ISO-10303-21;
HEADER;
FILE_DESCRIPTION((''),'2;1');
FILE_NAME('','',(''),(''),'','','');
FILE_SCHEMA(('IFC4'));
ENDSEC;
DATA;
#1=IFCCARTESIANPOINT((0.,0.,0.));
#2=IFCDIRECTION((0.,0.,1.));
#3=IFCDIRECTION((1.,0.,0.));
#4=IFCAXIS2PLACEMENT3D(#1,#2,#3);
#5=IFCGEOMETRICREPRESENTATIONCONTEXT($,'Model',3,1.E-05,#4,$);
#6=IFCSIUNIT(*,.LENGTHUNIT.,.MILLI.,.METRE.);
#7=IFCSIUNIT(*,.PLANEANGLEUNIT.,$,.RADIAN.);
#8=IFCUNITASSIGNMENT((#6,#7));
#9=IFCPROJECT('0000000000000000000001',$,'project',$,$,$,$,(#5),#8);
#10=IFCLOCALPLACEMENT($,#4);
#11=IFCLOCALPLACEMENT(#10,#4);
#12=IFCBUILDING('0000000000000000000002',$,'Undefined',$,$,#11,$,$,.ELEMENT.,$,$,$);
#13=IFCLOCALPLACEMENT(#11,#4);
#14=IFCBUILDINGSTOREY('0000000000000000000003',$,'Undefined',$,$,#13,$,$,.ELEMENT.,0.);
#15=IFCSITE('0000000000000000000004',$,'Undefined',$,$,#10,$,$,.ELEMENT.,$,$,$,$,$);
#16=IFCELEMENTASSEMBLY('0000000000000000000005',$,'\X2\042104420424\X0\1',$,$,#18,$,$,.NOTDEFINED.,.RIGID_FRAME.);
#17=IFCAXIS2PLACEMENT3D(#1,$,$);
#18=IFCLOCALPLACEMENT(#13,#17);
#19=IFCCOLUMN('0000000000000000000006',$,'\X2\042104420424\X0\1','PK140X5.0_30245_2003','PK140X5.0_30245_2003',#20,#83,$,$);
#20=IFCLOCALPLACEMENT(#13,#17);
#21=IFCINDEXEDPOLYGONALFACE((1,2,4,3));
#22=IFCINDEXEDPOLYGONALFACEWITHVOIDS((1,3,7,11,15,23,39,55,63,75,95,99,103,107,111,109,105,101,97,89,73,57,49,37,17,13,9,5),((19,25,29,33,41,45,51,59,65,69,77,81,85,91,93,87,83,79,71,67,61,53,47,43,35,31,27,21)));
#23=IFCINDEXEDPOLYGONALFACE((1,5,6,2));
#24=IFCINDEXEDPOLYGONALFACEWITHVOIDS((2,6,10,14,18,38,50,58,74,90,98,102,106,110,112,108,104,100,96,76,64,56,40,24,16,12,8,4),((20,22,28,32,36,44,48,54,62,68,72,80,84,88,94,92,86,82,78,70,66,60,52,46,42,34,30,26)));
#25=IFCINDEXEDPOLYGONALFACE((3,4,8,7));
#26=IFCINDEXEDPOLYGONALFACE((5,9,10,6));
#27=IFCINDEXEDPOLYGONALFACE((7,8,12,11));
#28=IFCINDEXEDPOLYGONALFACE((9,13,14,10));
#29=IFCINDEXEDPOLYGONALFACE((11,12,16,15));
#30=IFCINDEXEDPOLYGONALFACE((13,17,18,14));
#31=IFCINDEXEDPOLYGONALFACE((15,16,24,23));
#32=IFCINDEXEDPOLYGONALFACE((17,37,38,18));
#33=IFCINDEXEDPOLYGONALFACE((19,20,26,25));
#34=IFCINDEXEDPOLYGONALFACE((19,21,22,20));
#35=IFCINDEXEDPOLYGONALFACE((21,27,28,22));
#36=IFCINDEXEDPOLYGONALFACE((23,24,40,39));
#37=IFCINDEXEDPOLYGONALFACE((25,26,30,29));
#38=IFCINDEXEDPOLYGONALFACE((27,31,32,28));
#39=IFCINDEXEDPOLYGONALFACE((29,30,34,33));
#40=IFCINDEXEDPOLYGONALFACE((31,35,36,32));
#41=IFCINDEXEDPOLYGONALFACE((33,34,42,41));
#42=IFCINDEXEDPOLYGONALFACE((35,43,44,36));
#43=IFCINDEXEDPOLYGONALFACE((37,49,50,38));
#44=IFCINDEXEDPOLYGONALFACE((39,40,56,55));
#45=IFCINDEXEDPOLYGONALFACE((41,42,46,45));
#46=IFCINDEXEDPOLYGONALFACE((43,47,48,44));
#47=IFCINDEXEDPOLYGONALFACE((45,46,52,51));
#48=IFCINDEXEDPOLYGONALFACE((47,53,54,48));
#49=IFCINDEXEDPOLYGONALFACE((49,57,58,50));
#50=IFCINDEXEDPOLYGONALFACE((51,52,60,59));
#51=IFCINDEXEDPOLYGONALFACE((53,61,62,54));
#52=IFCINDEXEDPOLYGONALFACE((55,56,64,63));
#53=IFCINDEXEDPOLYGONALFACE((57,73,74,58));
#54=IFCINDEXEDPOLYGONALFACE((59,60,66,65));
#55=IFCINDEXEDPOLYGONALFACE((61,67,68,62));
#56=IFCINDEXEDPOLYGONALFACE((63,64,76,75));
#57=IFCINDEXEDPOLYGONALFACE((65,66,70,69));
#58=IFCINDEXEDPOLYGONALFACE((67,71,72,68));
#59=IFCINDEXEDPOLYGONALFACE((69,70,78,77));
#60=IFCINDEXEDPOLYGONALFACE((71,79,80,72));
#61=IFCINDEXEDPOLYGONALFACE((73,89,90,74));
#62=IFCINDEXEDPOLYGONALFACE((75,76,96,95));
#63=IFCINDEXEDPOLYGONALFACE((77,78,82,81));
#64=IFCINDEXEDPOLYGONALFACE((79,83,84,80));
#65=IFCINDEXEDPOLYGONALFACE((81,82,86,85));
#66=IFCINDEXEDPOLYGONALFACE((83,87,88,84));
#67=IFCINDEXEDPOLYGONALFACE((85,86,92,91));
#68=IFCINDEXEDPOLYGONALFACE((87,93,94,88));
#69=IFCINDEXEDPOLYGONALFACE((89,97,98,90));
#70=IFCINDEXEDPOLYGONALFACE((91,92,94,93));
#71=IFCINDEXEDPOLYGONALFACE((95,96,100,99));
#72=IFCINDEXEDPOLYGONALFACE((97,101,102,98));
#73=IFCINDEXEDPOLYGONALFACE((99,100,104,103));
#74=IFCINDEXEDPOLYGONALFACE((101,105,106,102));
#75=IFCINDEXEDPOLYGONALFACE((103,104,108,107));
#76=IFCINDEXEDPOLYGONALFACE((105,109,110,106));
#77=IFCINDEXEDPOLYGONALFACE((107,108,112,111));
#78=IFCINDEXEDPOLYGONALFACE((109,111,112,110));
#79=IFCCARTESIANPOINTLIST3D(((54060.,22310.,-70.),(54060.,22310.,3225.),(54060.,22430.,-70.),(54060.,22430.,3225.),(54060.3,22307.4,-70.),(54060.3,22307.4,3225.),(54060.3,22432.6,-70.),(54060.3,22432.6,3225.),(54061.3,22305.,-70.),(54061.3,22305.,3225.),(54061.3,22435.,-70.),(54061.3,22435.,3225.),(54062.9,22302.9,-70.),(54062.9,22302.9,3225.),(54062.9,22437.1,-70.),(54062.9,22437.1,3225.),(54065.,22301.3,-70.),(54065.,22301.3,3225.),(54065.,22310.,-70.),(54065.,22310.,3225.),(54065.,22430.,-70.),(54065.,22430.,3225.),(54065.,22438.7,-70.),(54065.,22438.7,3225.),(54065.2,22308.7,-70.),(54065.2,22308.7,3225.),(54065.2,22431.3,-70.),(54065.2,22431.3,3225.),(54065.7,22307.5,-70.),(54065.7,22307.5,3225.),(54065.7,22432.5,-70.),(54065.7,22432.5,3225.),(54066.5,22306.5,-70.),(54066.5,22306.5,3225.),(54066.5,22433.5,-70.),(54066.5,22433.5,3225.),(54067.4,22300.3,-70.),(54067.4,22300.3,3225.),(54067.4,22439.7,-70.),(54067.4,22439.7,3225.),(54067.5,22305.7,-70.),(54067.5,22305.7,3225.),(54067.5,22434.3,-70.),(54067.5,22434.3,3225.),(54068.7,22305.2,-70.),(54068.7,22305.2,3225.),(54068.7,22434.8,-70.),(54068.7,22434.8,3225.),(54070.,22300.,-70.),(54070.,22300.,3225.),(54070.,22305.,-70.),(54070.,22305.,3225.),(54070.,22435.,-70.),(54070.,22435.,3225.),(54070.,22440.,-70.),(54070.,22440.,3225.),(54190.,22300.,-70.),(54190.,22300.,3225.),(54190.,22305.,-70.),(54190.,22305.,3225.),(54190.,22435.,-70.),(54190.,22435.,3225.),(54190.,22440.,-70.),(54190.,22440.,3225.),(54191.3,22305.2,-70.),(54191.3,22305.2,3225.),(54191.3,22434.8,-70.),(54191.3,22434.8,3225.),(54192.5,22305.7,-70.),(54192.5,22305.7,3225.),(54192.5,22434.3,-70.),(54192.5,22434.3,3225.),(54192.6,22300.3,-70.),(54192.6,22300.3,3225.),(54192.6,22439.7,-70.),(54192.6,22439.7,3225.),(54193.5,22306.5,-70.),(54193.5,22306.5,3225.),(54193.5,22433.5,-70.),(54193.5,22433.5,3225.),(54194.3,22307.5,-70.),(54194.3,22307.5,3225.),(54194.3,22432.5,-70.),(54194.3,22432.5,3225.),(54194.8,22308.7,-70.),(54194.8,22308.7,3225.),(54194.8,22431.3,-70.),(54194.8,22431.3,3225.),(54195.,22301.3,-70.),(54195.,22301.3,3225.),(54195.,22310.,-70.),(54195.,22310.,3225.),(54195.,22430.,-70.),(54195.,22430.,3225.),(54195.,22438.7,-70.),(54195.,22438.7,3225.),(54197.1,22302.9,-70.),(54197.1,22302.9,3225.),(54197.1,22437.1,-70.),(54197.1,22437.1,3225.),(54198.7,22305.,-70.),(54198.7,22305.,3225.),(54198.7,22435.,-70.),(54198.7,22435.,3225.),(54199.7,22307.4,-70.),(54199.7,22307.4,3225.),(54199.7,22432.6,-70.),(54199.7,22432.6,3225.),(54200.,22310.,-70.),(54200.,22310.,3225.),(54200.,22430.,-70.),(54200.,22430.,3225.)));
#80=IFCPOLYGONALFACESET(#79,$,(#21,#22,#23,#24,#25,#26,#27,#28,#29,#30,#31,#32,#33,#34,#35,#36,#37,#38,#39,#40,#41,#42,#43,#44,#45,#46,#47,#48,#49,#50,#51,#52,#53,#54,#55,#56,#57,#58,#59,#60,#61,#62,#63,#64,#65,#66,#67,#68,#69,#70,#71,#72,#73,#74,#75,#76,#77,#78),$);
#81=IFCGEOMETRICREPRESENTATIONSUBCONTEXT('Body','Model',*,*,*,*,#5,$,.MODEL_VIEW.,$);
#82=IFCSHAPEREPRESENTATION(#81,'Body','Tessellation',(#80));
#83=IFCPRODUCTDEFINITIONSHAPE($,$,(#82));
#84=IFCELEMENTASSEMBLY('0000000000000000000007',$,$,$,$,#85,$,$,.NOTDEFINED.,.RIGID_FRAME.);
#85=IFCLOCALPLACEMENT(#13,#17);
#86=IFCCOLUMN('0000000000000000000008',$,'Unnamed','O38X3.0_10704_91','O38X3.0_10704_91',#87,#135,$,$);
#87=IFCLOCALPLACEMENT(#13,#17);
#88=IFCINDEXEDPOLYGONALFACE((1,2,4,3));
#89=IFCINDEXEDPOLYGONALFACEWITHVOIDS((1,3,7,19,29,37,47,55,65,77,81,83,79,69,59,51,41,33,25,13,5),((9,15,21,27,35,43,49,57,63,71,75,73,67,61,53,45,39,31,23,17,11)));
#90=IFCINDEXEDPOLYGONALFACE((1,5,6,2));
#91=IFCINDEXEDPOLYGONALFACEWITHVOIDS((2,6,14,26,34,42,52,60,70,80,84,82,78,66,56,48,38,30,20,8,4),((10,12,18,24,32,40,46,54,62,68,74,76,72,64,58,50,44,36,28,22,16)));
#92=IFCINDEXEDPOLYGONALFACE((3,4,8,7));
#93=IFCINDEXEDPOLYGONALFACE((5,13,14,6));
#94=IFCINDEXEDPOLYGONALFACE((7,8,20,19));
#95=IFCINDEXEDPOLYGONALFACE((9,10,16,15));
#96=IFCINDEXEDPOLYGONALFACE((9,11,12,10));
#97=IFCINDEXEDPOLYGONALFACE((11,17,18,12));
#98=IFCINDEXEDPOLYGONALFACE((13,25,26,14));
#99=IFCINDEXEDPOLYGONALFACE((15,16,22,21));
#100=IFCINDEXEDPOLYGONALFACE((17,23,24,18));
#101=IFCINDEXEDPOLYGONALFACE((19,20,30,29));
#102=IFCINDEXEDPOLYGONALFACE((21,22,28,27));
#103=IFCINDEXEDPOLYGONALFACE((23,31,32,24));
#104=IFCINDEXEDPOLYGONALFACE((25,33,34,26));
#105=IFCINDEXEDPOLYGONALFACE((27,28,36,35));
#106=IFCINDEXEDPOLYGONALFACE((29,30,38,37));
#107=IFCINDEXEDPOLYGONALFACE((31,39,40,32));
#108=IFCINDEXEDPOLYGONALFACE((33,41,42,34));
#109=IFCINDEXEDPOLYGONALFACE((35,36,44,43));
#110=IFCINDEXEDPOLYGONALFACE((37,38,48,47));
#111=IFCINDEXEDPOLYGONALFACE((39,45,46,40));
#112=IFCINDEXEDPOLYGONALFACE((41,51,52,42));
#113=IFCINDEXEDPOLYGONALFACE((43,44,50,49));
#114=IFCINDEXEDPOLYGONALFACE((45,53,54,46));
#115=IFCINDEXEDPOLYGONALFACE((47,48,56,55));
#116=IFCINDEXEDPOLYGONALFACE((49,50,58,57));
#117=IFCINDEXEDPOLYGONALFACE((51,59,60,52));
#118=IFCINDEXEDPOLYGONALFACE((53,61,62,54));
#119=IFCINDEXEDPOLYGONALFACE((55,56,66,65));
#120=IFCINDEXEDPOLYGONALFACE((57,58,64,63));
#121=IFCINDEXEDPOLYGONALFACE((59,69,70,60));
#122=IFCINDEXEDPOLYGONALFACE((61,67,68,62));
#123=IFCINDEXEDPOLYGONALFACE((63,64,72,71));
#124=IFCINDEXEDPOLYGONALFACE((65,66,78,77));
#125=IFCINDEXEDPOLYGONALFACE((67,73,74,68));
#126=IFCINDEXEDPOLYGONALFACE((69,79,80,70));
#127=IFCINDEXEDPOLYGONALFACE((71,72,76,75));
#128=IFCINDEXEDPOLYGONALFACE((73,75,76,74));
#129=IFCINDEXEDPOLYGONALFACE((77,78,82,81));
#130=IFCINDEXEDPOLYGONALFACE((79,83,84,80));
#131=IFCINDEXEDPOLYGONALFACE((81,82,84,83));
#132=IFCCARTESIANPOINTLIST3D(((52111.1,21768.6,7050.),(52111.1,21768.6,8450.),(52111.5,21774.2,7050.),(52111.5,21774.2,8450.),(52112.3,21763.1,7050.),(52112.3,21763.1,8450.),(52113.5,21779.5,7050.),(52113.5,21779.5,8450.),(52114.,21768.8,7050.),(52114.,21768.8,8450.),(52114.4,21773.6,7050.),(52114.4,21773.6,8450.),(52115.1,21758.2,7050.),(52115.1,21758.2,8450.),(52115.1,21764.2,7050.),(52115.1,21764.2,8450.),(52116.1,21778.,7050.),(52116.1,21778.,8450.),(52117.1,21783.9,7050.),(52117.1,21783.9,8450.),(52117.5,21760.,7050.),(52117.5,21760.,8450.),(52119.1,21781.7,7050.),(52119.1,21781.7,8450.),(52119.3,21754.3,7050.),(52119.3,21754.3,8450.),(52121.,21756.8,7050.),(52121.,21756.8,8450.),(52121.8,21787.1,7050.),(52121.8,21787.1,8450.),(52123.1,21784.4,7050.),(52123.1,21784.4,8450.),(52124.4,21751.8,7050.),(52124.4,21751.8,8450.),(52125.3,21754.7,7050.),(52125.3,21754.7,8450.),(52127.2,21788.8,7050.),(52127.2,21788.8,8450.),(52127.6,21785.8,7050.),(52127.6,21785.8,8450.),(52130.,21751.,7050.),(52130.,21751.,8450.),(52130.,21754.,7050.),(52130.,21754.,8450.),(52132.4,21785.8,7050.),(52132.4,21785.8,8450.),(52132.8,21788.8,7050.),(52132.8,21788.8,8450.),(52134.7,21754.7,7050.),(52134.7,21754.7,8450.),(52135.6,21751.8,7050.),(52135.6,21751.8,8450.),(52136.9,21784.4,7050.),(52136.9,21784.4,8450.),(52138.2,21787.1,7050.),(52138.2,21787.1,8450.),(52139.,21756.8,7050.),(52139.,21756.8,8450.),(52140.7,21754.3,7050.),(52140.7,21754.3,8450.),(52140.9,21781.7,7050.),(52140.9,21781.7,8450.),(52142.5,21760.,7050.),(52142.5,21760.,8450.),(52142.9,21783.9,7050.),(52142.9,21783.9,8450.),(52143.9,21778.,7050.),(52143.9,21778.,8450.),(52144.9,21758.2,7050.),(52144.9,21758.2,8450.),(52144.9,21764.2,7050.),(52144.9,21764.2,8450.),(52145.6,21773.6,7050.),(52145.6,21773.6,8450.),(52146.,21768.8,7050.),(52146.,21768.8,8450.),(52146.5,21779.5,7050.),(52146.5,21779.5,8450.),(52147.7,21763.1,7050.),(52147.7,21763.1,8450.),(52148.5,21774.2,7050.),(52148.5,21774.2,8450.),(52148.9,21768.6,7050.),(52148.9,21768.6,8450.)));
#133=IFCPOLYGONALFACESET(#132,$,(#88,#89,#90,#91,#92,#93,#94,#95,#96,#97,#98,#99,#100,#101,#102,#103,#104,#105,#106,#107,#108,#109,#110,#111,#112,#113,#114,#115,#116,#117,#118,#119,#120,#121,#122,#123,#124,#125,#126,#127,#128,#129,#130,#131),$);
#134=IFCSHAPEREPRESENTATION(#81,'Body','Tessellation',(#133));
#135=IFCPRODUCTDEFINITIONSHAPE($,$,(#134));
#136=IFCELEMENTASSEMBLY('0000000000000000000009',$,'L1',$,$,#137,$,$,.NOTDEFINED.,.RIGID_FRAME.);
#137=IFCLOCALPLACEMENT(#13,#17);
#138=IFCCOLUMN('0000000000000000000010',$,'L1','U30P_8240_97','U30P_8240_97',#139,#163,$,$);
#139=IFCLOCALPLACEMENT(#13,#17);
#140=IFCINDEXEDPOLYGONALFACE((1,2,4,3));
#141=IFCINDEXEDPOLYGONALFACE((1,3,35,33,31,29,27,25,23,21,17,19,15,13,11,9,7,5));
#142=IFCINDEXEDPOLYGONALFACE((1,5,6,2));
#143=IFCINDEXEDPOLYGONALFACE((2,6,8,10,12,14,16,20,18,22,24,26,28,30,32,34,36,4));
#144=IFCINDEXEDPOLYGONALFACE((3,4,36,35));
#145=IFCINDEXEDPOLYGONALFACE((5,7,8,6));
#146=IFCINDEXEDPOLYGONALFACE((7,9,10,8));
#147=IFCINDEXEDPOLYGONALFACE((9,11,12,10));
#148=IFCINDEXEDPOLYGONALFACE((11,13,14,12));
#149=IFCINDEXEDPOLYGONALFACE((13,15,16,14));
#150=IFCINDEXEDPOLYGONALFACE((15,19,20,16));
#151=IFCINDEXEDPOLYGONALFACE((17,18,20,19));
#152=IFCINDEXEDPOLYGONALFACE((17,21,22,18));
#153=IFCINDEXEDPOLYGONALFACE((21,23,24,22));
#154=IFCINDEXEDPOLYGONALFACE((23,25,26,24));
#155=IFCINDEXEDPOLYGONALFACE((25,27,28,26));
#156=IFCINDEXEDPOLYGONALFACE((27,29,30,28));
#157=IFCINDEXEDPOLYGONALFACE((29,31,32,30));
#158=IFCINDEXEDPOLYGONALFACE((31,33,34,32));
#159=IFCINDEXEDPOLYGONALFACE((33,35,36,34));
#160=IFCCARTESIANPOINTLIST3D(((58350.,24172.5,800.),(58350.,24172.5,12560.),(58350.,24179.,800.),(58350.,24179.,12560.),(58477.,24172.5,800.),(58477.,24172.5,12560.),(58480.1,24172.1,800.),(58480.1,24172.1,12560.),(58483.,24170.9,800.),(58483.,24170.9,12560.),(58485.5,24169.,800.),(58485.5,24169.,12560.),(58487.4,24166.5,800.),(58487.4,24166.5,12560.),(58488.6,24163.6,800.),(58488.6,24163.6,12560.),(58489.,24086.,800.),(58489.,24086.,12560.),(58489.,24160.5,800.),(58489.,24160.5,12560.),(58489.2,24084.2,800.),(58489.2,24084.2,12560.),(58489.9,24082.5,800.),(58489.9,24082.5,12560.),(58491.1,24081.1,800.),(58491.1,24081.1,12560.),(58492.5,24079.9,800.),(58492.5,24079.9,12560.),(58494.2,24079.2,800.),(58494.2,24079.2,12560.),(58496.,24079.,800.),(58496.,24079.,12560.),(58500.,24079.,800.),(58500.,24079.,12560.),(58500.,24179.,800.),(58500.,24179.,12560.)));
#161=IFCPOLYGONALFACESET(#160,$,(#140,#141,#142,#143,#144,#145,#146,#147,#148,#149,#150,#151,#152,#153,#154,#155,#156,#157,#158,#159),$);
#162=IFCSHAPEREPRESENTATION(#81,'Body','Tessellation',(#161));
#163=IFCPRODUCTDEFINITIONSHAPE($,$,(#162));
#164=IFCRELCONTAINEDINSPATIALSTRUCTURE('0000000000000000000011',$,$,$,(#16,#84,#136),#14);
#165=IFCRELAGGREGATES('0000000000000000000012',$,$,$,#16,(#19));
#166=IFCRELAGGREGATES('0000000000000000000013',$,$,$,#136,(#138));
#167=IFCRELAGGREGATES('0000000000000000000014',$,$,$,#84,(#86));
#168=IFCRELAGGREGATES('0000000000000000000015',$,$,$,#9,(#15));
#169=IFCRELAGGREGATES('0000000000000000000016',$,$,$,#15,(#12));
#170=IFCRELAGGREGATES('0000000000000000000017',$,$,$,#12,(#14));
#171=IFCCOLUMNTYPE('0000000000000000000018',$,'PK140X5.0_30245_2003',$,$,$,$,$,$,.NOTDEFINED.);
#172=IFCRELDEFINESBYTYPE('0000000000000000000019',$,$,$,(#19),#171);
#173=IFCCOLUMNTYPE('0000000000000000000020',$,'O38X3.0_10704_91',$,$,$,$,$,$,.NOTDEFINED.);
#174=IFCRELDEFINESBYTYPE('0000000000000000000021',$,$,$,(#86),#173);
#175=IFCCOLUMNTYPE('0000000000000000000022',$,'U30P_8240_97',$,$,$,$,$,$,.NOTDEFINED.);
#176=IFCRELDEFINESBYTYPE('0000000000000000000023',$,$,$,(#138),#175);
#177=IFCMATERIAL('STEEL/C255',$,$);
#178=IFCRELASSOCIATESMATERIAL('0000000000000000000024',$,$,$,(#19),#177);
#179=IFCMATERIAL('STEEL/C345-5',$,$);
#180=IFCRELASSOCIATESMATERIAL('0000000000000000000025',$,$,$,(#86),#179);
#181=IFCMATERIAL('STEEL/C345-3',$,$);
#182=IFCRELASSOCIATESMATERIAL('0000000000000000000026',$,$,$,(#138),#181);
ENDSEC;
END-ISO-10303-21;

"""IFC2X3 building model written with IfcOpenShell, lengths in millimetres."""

from ifc_helpers import new_model, si_unit, frame, origin_with_axes, origin_2d_with_axis, place, context, subcontext, project, spatial, hollow_rectangle, hollow_circle, u_section, extrude, clip, halfspace, material, type_object, element, aggregate, save


model = new_model("IFC2X3")

# Units and contexts
model_context = context("Model", 3, precision=1e-05, world=origin_with_axes())
body_context = subcontext(model_context, "Body", "Model", "MODEL_VIEW")
ifc_project = project(units=[si_unit("LENGTHUNIT", "METRE", prefix="MILLI"), si_unit("PLANEANGLEUNIT", "RADIAN")], contexts=[model_context])

# Site, building, storey
site_placement = place(None, origin_with_axes())
site = spatial("IfcSite", under=ifc_project, at=site_placement, Name="Undefined", CompositionType="ELEMENT")
building_placement = place(site_placement, origin_with_axes())
building = spatial("IfcBuilding", under=site, at=building_placement, Name="Undefined", CompositionType="ELEMENT")
storey_placement = place(building_placement, origin_with_axes())
storey = spatial("IfcBuildingStorey", under=building, at=storey_placement, Name="Undefined", CompositionType="ELEMENT", Elevation=0.0)

# Element assemblies, columns
assembly_1_placement = place(storey_placement, origin_with_axes())
assembly_1 = element("IfcElementAssembly", 1, at=assembly_1_placement, inside=storey, Name="СтФ1", AssemblyPlace="NOTDEFINED", PredefinedType="RIGID_FRAME")
ifc_material_1 = material(Name="STEEL/C255")
column_type_1 = type_object("IfcColumnType", Name="PK140X5.0_30245_2003", PredefinedType="NOTDEFINED")
column_1_placement = place(assembly_1_placement, frame((54130.0, 22370.0, -70.0), z_axis=(0.0, 0.0, 1.0), x_axis=(0.0, -1.0, 0.0)))
column_1 = element("IfcColumn", 2, at=column_1_placement, type_object=column_type_1, material=ifc_material_1, Name="СтФ1", Description="PK140X5.0_30245_2003", ObjectType="PK140X5.0_30245_2003", context=body_context, shape_type="Clipping", body=[
    clip(extrude(hollow_rectangle(XDim=140.0, YDim=140.0, WallThickness=5.0, InnerFilletRadius=5.0, OuterFilletRadius=10.0, at=origin_2d_with_axis()), frame((0.0, 0.0, 3295.0), z_axis=(0.0, 0.0, -1.0), x_axis=(0.0, 1.0, 0.0)), (0.0, 0.0, 1.0), 3295.0), halfspace(frame((70.0, 210.0, 6119.7), z_axis=(-0.049938, 0.0, 0.998752), x_axis=(0.0, -1.0, 0.0)), False)),
])
aggregate(assembly_1, [column_1])
assembly_2_placement = place(storey_placement, origin_with_axes())
assembly_2 = element("IfcElementAssembly", 3, at=assembly_2_placement, inside=storey, AssemblyPlace="NOTDEFINED", PredefinedType="RIGID_FRAME")
ifc_material_2 = material(Name="STEEL/C345-5")
column_type_2 = type_object("IfcColumnType", Name="O38X3.0_10704_91", PredefinedType="NOTDEFINED")
column_2_placement = place(assembly_2_placement, frame((52130.0, 21770.0, 7050.0), z_axis=(0.0, 0.0, 1.0), x_axis=(-1.0, 0.0, 0.0)))
column_2 = element("IfcColumn", 4, at=column_2_placement, type_object=column_type_2, material=ifc_material_2, Name="Unnamed", Description="O38X3.0_10704_91", ObjectType="O38X3.0_10704_91", context=body_context, shape_type="SweptSolid", body=[
    extrude(hollow_circle(Radius=19.0, WallThickness=3.0, at=origin_2d_with_axis()), frame((0.0, 0.0, 1400.0), z_axis=(0.0, 0.0, -1.0), x_axis=(0.0, 1.0, 0.0)), (0.0, 0.0, 1.0), 1400.0),
])
assembly_3_placement = place(storey_placement, origin_with_axes())
assembly_3 = element("IfcElementAssembly", 5, at=assembly_3_placement, inside=storey, Name="L1", AssemblyPlace="NOTDEFINED", PredefinedType="RIGID_FRAME")
ifc_material_3 = material(Name="STEEL/C345-3")
column_type_3 = type_object("IfcColumnType", Name="U30P_8240_97", PredefinedType="NOTDEFINED")
column_3_placement = place(assembly_3_placement, frame((58350.0, 24129.0, 800.0), z_axis=(0.0, 0.0, 1.0), x_axis=(-1.0, 0.0, 0.0)))
column_3 = element("IfcColumn", 6, at=column_3_placement, type_object=column_type_3, material=ifc_material_3, Name="L1", Description="U30P_8240_97", ObjectType="U30P_8240_97", context=body_context, shape_type="Clipping", body=[
    clip(extrude(u_section(Depth=300.0, FlangeWidth=100.0, WebThickness=6.5, FlangeThickness=11.0, FilletRadius=12.0, EdgeRadius=7.0, at=origin_2d_with_axis()), frame((0.0, 0.0, 11760.0), z_axis=(0.0, 0.0, -1.0), x_axis=(0.0, 1.0, 0.0)), (0.0, 0.0, 1.0), 11760.0), halfspace(frame((0.0, -50.0, 11780.0), z_axis=(1.0, 0.0, 0.0), x_axis=(0.0, 1.0, 0.0)), False)),
])
aggregate(assembly_3, [column_3])

aggregate(assembly_2, [column_2])

save(model, "model.ifc")
